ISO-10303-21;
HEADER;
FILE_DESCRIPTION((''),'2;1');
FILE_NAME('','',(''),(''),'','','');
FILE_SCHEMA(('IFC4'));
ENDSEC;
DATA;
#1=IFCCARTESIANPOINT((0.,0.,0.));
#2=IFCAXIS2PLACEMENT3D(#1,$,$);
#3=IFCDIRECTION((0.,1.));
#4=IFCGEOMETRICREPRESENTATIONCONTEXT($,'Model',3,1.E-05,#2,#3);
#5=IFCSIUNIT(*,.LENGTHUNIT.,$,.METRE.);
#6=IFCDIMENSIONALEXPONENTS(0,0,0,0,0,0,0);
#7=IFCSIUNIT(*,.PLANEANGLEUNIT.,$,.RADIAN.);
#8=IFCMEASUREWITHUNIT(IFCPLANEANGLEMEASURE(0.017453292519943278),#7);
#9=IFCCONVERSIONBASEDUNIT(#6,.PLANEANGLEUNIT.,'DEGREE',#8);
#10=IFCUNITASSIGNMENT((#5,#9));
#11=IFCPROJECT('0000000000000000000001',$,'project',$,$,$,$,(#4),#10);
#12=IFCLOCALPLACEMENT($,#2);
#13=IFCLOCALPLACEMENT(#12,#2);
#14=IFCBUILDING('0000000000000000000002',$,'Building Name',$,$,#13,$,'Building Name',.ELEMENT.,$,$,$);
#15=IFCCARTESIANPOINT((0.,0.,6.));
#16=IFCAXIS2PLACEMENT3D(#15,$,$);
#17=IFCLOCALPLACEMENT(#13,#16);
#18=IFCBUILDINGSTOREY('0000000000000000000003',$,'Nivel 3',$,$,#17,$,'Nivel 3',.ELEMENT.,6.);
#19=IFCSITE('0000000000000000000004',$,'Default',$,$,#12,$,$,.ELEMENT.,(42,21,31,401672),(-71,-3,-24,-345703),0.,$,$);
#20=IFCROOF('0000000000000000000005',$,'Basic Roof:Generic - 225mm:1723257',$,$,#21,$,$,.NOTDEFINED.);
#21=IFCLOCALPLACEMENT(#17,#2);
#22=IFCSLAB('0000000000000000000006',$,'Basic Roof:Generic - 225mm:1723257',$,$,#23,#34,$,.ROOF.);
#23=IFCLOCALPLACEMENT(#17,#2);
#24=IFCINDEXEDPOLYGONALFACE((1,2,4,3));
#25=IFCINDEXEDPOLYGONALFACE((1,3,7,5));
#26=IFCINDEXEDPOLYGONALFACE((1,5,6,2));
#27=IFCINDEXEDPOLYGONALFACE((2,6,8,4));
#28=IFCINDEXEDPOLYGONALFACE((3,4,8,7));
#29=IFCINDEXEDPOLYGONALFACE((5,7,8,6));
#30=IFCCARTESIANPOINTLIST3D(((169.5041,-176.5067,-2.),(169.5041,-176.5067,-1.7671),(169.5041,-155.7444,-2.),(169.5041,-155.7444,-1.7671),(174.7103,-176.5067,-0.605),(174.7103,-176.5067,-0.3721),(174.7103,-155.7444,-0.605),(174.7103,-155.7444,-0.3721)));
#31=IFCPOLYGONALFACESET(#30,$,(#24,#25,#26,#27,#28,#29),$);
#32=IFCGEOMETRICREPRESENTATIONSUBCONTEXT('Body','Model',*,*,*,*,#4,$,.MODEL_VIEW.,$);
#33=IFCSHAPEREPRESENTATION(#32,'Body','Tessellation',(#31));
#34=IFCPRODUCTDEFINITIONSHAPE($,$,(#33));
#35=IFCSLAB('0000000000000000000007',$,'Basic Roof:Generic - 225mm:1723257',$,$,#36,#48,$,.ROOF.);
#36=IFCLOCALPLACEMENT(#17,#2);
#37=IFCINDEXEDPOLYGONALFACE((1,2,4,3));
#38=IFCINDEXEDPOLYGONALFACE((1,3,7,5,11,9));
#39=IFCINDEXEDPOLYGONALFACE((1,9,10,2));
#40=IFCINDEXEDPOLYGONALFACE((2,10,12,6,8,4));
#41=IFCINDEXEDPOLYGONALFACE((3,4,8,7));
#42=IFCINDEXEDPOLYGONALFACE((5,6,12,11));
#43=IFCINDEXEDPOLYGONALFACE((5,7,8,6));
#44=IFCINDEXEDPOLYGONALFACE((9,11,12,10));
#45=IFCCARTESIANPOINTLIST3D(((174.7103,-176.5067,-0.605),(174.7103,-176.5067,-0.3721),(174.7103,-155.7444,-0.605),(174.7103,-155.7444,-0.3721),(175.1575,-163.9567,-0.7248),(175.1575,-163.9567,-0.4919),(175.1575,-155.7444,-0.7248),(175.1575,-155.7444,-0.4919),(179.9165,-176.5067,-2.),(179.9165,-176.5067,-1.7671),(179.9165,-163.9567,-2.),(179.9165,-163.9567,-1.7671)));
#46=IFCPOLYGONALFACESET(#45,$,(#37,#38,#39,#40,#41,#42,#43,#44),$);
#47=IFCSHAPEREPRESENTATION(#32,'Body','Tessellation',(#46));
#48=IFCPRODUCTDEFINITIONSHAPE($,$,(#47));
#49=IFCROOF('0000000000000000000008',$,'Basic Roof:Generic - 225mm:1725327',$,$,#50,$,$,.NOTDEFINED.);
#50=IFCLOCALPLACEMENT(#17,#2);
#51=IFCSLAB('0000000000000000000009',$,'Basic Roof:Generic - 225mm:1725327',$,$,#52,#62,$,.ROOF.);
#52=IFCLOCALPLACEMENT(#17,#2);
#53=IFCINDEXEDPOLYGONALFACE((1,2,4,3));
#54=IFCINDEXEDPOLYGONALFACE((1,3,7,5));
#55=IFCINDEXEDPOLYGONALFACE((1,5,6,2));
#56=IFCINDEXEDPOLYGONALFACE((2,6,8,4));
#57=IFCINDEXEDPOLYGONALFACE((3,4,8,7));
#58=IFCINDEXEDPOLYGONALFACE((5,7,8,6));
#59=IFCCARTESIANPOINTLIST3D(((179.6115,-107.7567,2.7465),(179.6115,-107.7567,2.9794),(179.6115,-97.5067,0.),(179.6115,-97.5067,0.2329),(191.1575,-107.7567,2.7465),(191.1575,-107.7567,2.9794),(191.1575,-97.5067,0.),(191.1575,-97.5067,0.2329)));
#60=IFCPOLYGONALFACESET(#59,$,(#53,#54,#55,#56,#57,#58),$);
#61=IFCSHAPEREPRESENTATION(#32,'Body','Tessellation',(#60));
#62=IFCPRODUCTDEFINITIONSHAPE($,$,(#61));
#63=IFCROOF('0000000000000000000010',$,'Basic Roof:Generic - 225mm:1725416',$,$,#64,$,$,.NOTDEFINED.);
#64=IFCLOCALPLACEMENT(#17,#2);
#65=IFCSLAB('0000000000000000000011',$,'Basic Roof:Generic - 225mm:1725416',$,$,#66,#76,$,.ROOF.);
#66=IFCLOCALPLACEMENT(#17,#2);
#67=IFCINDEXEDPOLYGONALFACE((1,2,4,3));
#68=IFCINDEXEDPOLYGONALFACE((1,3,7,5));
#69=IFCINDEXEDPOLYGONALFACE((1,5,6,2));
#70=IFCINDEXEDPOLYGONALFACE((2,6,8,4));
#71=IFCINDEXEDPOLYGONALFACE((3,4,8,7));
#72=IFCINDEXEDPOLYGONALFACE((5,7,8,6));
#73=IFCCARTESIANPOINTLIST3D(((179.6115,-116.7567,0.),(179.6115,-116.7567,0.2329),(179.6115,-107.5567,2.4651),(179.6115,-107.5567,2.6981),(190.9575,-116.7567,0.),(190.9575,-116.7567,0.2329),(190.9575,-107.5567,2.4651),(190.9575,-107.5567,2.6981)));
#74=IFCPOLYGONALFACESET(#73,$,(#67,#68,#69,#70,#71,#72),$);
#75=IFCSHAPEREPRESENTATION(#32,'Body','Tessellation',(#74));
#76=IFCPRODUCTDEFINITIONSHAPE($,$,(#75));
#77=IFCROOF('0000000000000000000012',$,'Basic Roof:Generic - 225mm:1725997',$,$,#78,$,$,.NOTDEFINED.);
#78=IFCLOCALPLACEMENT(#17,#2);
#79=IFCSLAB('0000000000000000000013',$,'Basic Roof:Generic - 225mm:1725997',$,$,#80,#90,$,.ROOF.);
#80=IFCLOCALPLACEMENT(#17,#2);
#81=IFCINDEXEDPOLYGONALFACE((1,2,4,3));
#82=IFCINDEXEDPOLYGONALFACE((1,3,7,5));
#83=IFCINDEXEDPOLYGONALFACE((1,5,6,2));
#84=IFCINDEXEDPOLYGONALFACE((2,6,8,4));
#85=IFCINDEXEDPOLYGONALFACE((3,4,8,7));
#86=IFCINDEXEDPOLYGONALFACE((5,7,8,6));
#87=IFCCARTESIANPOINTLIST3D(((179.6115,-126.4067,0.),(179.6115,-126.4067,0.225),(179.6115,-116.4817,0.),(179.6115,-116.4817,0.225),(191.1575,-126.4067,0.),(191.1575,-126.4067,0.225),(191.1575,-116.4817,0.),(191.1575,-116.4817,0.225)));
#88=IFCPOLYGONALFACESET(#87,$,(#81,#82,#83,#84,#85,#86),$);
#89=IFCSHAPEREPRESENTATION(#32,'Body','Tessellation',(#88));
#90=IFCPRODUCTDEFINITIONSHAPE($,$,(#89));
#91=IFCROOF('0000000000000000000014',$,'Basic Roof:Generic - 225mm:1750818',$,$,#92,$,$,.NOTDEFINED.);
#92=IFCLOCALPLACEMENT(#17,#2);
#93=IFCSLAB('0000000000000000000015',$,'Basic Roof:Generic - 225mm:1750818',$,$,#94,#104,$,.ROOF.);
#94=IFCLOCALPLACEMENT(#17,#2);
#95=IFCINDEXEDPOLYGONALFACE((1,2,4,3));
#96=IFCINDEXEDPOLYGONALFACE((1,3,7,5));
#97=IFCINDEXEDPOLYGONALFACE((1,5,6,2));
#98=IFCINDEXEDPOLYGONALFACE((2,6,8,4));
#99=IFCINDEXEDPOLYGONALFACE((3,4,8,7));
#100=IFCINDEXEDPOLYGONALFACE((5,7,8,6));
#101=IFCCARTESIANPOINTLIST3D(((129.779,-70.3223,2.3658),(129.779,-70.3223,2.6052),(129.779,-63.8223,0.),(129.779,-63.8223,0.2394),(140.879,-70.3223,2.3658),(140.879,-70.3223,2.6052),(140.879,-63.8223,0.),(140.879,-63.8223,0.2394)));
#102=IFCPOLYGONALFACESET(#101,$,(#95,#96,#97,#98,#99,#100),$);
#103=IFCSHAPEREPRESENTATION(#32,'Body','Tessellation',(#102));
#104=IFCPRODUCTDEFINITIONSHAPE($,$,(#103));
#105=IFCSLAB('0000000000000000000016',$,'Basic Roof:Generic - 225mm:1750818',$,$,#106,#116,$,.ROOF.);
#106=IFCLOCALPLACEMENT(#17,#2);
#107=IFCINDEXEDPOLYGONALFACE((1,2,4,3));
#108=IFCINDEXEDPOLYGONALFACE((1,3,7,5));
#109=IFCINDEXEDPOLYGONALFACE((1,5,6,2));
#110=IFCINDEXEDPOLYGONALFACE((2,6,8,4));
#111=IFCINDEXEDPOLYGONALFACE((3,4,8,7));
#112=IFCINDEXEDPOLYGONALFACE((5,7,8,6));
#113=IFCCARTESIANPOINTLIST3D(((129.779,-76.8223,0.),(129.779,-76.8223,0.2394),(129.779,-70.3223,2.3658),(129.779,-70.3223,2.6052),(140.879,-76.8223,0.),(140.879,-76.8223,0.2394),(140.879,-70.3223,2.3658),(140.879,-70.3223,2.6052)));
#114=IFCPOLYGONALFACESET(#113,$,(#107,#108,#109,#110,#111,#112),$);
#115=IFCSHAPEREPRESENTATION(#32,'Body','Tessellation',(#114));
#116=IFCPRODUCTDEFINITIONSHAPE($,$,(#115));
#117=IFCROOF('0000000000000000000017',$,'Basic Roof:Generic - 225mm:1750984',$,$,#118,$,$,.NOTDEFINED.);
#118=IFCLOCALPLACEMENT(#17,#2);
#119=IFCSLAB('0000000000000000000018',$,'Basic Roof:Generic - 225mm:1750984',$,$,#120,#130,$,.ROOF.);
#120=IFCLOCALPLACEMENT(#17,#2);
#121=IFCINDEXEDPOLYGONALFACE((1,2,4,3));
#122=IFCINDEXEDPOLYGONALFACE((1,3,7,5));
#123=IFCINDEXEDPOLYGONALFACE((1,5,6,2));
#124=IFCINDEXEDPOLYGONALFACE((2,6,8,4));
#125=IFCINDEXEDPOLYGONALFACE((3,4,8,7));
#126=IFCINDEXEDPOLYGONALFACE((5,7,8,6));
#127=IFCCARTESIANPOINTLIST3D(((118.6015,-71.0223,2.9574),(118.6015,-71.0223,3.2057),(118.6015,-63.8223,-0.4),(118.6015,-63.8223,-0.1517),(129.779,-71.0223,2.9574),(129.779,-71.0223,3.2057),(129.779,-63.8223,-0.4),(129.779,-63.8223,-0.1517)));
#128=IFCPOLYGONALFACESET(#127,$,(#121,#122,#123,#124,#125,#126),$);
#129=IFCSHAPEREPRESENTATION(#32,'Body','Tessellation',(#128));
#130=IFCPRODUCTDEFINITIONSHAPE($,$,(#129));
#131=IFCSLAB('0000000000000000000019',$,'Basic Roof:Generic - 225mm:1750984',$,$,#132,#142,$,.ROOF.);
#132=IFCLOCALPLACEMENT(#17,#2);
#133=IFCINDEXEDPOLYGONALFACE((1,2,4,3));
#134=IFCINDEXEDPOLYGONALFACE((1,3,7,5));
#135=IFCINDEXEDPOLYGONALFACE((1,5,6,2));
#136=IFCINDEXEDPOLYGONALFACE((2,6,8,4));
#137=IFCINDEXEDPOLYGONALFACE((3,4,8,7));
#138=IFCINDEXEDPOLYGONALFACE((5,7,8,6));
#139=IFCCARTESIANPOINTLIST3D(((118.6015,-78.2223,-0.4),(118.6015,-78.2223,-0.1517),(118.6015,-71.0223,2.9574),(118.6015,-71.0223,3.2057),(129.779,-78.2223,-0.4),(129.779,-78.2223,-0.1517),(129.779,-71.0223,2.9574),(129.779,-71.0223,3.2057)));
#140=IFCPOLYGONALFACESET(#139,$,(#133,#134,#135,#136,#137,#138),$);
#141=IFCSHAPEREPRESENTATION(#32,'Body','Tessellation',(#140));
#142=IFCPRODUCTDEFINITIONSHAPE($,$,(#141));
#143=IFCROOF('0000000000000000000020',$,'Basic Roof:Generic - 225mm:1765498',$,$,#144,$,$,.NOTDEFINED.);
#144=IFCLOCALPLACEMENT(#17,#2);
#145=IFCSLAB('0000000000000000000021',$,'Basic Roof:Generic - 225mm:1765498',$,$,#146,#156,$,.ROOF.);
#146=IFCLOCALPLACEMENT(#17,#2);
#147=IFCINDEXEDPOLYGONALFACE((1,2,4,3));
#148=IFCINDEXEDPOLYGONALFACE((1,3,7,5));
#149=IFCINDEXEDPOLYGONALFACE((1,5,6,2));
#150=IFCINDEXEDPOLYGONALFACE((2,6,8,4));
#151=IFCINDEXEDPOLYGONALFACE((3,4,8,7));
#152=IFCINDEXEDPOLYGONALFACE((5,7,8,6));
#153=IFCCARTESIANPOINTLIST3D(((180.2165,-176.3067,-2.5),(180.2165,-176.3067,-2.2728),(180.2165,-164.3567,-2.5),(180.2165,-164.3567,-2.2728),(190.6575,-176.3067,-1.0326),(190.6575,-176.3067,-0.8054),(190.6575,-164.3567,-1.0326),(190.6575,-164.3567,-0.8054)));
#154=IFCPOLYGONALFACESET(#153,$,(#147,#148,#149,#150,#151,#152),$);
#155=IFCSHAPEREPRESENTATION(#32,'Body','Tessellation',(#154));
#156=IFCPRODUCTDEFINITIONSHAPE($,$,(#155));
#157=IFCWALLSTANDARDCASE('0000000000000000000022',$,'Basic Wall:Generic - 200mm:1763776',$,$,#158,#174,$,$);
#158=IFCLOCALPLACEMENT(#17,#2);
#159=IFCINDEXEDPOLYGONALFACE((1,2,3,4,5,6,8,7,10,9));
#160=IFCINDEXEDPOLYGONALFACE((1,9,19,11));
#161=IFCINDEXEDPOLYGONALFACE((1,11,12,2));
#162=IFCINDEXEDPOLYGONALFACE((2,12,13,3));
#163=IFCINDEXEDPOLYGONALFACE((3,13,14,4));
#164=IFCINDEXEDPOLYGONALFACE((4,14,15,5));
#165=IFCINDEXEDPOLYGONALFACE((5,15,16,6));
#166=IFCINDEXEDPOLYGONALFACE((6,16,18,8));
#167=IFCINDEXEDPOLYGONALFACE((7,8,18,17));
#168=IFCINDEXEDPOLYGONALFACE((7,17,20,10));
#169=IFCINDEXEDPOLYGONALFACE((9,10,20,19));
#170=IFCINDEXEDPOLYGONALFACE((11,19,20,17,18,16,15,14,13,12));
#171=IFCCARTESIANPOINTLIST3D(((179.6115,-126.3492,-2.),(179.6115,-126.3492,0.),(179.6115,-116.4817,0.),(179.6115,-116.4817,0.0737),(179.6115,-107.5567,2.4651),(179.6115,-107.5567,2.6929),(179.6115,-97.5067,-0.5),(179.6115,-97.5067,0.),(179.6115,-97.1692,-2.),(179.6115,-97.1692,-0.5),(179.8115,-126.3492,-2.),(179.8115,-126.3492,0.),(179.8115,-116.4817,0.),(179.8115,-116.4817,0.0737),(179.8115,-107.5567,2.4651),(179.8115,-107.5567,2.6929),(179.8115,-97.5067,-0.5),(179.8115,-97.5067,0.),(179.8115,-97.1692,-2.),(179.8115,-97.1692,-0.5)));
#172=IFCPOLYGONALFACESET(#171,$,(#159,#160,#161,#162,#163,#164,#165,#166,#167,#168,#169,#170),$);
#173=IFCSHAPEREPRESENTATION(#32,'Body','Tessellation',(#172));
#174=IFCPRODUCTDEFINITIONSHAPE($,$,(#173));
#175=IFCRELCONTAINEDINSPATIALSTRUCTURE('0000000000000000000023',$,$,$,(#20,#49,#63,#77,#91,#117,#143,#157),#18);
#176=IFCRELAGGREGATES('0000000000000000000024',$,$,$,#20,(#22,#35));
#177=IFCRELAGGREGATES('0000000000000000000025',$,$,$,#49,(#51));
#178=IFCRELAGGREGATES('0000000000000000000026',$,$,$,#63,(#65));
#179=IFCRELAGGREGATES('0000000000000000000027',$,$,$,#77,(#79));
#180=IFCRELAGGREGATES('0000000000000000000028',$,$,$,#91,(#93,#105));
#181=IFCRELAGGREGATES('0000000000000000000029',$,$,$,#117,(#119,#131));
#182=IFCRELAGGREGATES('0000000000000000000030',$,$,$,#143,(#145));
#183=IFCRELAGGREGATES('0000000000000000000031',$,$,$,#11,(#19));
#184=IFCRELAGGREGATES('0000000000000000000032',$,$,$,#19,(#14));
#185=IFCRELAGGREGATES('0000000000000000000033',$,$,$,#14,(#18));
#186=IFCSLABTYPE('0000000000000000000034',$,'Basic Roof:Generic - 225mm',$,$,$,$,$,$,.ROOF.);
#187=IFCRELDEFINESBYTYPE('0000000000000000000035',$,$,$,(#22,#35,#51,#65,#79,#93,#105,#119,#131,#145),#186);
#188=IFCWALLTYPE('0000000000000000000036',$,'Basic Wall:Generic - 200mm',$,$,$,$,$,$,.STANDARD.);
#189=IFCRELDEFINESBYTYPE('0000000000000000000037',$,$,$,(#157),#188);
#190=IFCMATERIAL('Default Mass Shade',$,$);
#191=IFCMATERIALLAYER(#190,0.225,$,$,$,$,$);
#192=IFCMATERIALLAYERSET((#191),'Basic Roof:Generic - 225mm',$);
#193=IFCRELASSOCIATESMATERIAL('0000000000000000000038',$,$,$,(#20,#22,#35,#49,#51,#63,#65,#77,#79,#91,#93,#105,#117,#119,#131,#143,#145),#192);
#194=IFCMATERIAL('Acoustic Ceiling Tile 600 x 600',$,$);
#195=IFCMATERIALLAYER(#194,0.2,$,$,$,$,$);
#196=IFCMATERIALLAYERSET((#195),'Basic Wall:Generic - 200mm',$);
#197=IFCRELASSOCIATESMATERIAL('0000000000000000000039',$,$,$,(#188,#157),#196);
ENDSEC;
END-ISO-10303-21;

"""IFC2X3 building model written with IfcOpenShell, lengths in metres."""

from ifc_helpers import new_model, entity, si_unit, converted_unit, direction, frame, frame_2d, origin, place, context, subcontext, project, spatial, polyline, rectangle, outline, extrude, clip, bounded_halfspace, material, layer, layer_set, layer_usage, type_object, element, aggregate, save


model = new_model("IFC2X3")

# Units and contexts
model_context = context("Model", 3, precision=1e-05, world=origin(), true_north=direction((0.0, 1.0)))
body_context = subcontext(model_context, "Body", "Model", "MODEL_VIEW")
ifc_project = project(units=[si_unit("LENGTHUNIT", "METRE"), converted_unit("PLANEANGLEUNIT", "DEGREE", entity("IfcPlaneAngleMeasure", 0.017453292519943278), si_unit("PLANEANGLEUNIT", "RADIAN"), dimensions=[0, 0, 0, 0, 0, 0, 0])], contexts=[model_context])

# Site, building, storey
site_placement = place(None, origin())
site = spatial("IfcSite", under=ifc_project, at=site_placement, Name="Default", CompositionType="ELEMENT", RefLatitude=(42, 21, 31, 401672), RefLongitude=(-71, -3, -24, -345703), RefElevation=0.0)
building_placement = place(site_placement, origin())
building = spatial("IfcBuilding", under=site, at=building_placement, Name="Building Name", LongName="Building Name", CompositionType="ELEMENT")
storey_placement = place(building_placement, frame((0.0, 0.0, 6.0)))
storey = spatial("IfcBuildingStorey", under=building, at=storey_placement, Name="Nivel 3", LongName="Nivel 3", CompositionType="ELEMENT", Elevation=6.0)

# Shared definitions
ifc_material_1 = material(Name="Default Mass Shade")
ifc_layer_1 = layer(ifc_material_1, 0.225)
ifc_layer_set_1 = layer_set([ifc_layer_1], Name="Basic Roof:Generic - 225mm")
slab_type = type_object("IfcSlabType", Name="Basic Roof:Generic - 225mm", PredefinedType="ROOF")

# Roof, slabs
roof_1_placement = place(storey_placement, frame((169.5041, -176.5067, -2.0)))
roof_1 = element("IfcRoof", 1, at=roof_1_placement, inside=storey, material=ifc_layer_set_1, Name="Basic Roof:Generic - 225mm:1723257", ShapeType="NOTDEFINED")
slab_1_placement = place(roof_1_placement, origin())
slab_1 = element("IfcSlab", 2, at=slab_1_placement, type_object=slab_type, material=ifc_layer_set_1, Name="Basic Roof:Generic - 225mm:1723257", PredefinedType="ROOF", context=body_context, shape_type="SweptSolid", body=[
    extrude(rectangle(XDim=20.7623, YDim=5.3898, at=frame_2d((0.0, 0.0), x_axis=(0.0, 1.0))), frame((2.6031, 10.3812, 0.6975), z_axis=(-0.258819, 0.0, 0.965926), x_axis=(0.965926, 0.0, 0.258819)), (0.258819, 0.0, 0.965926), 0.2329),
])
slab_2_placement = place(roof_1_placement, origin())
slab_2 = element("IfcSlab", 3, at=slab_2_placement, type_object=slab_type, material=ifc_layer_set_1, Name="Basic Roof:Generic - 225mm:1723257", PredefinedType="ROOF", context=body_context, shape_type="SweptSolid", body=[
    extrude(outline(polyline([(-2.6949, 10.3812), (-2.6949, -10.3812), (2.6949, -10.3812), (2.6949, 2.1688), (-2.2319, 2.1688), (-2.2319, 10.3812), (-2.6949, 10.3812)])), frame((7.8093, 10.3812, 0.6975), z_axis=(0.258819, 0.0, 0.965926), x_axis=(0.965926, 0.0, -0.258819)), (-0.258819, 0.0, 0.965926), 0.2329),
])
aggregate(roof_1, [slab_1, slab_2])

# Roofs, slabs
roof_2_placement = place(storey_placement, frame((179.6115, -107.7567, 0.0)))
roof_2 = element("IfcRoof", 4, at=roof_2_placement, inside=storey, material=ifc_layer_set_1, Name="Basic Roof:Generic - 225mm:1725327", ShapeType="NOTDEFINED")
slab_3_placement = place(roof_2_placement, origin())
slab_3 = element("IfcSlab", 5, at=slab_3_placement, type_object=slab_type, material=ifc_layer_set_1, Name="Basic Roof:Generic - 225mm:1725327", PredefinedType="ROOF", context=body_context, shape_type="SweptSolid", body=[
    extrude(rectangle(XDim=11.546, YDim=10.6116, at=frame_2d((0.0, 0.0), x_axis=(-1.0, 0.0))), frame((5.773, 5.125, 1.3732), z_axis=(0.0, 0.258819, 0.965926), x_axis=(1.0, 0.0, 0.0)), (0.0, -0.258819, 0.965926), 0.2329),
])
aggregate(roof_2, [slab_3])
roof_3_placement = place(storey_placement, frame((179.6115, -116.7567, 0.0)))
roof_3 = element("IfcRoof", 6, at=roof_3_placement, inside=storey, material=ifc_layer_set_1, Name="Basic Roof:Generic - 225mm:1725416", ShapeType="NOTDEFINED")
slab_4_placement = place(roof_3_placement, origin())
slab_4 = element("IfcSlab", 7, at=slab_4_placement, type_object=slab_type, material=ifc_layer_set_1, Name="Basic Roof:Generic - 225mm:1725416", PredefinedType="ROOF", context=body_context, shape_type="SweptSolid", body=[
    extrude(rectangle(XDim=9.5245, YDim=11.346, at=frame_2d((0.0, 0.0), x_axis=(0.0, -1.0))), frame((5.673, 4.6, 1.2326), z_axis=(0.0, -0.258819, 0.965926), x_axis=(1.0, 0.0, 0.0)), (0.0, 0.258819, 0.965926), 0.2329),
])
aggregate(roof_3, [slab_4])
roof_4_placement = place(storey_placement, frame((179.6115, -126.4067, 0.0)))
roof_4 = element("IfcRoof", 8, at=roof_4_placement, inside=storey, material=ifc_layer_set_1, Name="Basic Roof:Generic - 225mm:1725997", ShapeType="NOTDEFINED")
slab_5_placement = place(roof_4_placement, origin())
slab_5 = element("IfcSlab", 9, at=slab_5_placement, type_object=slab_type, material=ifc_layer_set_1, Name="Basic Roof:Generic - 225mm:1725997", PredefinedType="ROOF", context=body_context, shape_type="SweptSolid", body=[
    extrude(rectangle(XDim=9.925, YDim=11.546, at=frame_2d((0.0, 0.0), x_axis=(0.0, -1.0))), frame((5.773, 4.9625, 0.0)), (0.0, 0.0, 1.0), 0.225),
])
aggregate(roof_4, [slab_5])

# Roofs, slabs
roof_5_placement = place(storey_placement, frame((129.779, -76.8223, 0.0)))
roof_5 = element("IfcRoof", 10, at=roof_5_placement, inside=storey, material=ifc_layer_set_1, Name="Basic Roof:Generic - 225mm:1750818", ShapeType="NOTDEFINED")
slab_6_placement = place(roof_5_placement, origin())
slab_6 = element("IfcSlab", 11, at=slab_6_placement, type_object=slab_type, material=ifc_layer_set_1, Name="Basic Roof:Generic - 225mm:1750818", PredefinedType="ROOF", context=body_context, shape_type="SweptSolid", body=[
    extrude(rectangle(XDim=6.9172, YDim=11.1, at=frame_2d((0.0, 0.0), x_axis=(0.0, -1.0))), frame((5.55, 9.75, 1.1829), z_axis=(0.0, 0.34202, 0.939693), x_axis=(1.0, 0.0, 0.0)), (0.0, -0.34202, 0.939693), 0.2394),
])
slab_7_placement = place(roof_5_placement, origin())
slab_7 = element("IfcSlab", 12, at=slab_7_placement, type_object=slab_type, material=ifc_layer_set_1, Name="Basic Roof:Generic - 225mm:1750818", PredefinedType="ROOF", context=body_context, shape_type="SweptSolid", body=[
    extrude(rectangle(XDim=11.1, YDim=6.9172, at=frame_2d((0.0, 0.0), x_axis=(-1.0, 0.0))), frame((5.55, 3.25, 1.1829), z_axis=(0.0, -0.34202, 0.939693), x_axis=(1.0, 0.0, 0.0)), (0.0, 0.34202, 0.939693), 0.2394),
])
aggregate(roof_5, [slab_6, slab_7])
roof_6_placement = place(storey_placement, frame((118.6015, -78.2223, -0.4)))
roof_6 = element("IfcRoof", 13, at=roof_6_placement, inside=storey, material=ifc_layer_set_1, Name="Basic Roof:Generic - 225mm:1750984", ShapeType="NOTDEFINED")
slab_8_placement = place(roof_6_placement, origin())
slab_8 = element("IfcSlab", 14, at=slab_8_placement, type_object=slab_type, material=ifc_layer_set_1, Name="Basic Roof:Generic - 225mm:1750984", PredefinedType="ROOF", context=body_context, shape_type="SweptSolid", body=[
    extrude(rectangle(XDim=7.9443, YDim=11.1776, at=frame_2d((0.0, 0.0), x_axis=(0.0, -1.0))), frame((5.5888, 10.8, 1.6787), z_axis=(0.0, 0.422618, 0.906308), x_axis=(1.0, 0.0, 0.0)), (0.0, -0.422618, 0.906308), 0.2483),
])
slab_9_placement = place(roof_6_placement, origin())
slab_9 = element("IfcSlab", 15, at=slab_9_placement, type_object=slab_type, material=ifc_layer_set_1, Name="Basic Roof:Generic - 225mm:1750984", PredefinedType="ROOF", context=body_context, shape_type="SweptSolid", body=[
    extrude(rectangle(XDim=11.1776, YDim=7.9443, at=frame_2d((0.0, 0.0), x_axis=(-1.0, 0.0))), frame((5.5888, 3.6, 1.6787), z_axis=(0.0, -0.422618, 0.906308), x_axis=(1.0, 0.0, 0.0)), (0.0, 0.422618, 0.906308), 0.2483),
])
aggregate(roof_6, [slab_8, slab_9])

# Roof, slab
roof_7_placement = place(storey_placement, frame((180.2165, -176.3067, -2.5)))
roof_7 = element("IfcRoof", 16, at=roof_7_placement, inside=storey, material=ifc_layer_set_1, Name="Basic Roof:Generic - 225mm:1765498", ShapeType="NOTDEFINED")
slab_10_placement = place(roof_7_placement, origin())
slab_10 = element("IfcSlab", 17, at=slab_10_placement, type_object=slab_type, material=ifc_layer_set_1, Name="Basic Roof:Generic - 225mm:1765498", PredefinedType="ROOF", context=body_context, shape_type="SweptSolid", body=[
    extrude(rectangle(XDim=10.5436, YDim=11.95, at=frame_2d((0.0, 0.0), x_axis=(1.0, 0.0))), frame((5.2205, 5.975, 0.7337), z_axis=(-0.139173, 0.0, 0.990268), x_axis=(0.990268, 0.0, 0.139173)), (0.139173, 0.0, 0.990268), 0.2272),
])
aggregate(roof_7, [slab_10])

# Wall
ifc_material_2 = material(Name="Acoustic Ceiling Tile 600 x 600")
ifc_layer_2 = layer(ifc_material_2, 0.2)
ifc_layer_set_2 = layer_set([ifc_layer_2], Name="Basic Wall:Generic - 200mm")
ifc_layer_usage = layer_usage(ifc_layer_set_2, "AXIS2", "NEGATIVE", 0.1)
wall_type = type_object("IfcWallType", Name="Basic Wall:Generic - 200mm", PredefinedType="STANDARD", material=ifc_layer_set_2)
wall_placement = place(storey_placement, frame((179.7115, -126.3492, -2.0), z_axis=(0.0, 0.0, 1.0), x_axis=(0.0, 1.0, 0.0)))
element("IfcWallStandardCase", 18, at=wall_placement, inside=storey, type_object=wall_type, material=ifc_layer_usage, Name="Basic Wall:Generic - 200mm:1763776", context=body_context, shape_type="Clipping", body=[
    clip(clip(clip(clip(extrude(rectangle(XDim=29.18, YDim=0.2, at=frame_2d((14.59, 0.0), x_axis=(-1.0, 0.0))), origin(), (0.0, 0.0, 1.0), 4.6929), bounded_halfspace(frame((18.7925, -0.1, 4.6929), z_axis=(0.258819, 0.0, 0.965926), x_axis=(0.0, 1.0, 0.0)), False, frame((18.7925, -0.1, 4.6929)), polyline([(0.0, 0.0), (10.05, 0.0), (10.05, 0.2), (0.0, 0.2), (0.0, 0.0)]))), bounded_halfspace(frame((9.8675, -0.1, 2.0737), z_axis=(-0.258819, 0.0, 0.965926), x_axis=(0.0, -1.0, 0.0)), False, frame((9.8675, -0.1, 2.0737)), polyline([(0.0, 0.0), (8.925, 0.0), (8.925, 0.2), (0.0, 0.2), (0.0, 0.0)]))), bounded_halfspace(frame((9.8675, -0.1, 2.0), z_axis=(0.0, 0.0, 1.0), x_axis=(0.0, -1.0, 0.0)), False, frame((9.8675, -0.1, 2.0)), polyline([(0.0, 0.0), (0.0, 0.2), (-9.8675, 0.2), (-9.8675, 0.0), (0.0, 0.0)]))), bounded_halfspace(frame((28.8425, -0.1, 1.5), z_axis=(0.0, 0.0, 1.0), x_axis=(0.0, 1.0, 0.0)), False, frame((28.8425, -0.1, 1.5)), polyline([(0.0, 0.0), (0.3375, 0.0), (0.3375, 0.2), (0.0, 0.2), (0.0, 0.0)]))),
])

save(model, "model.ifc")
